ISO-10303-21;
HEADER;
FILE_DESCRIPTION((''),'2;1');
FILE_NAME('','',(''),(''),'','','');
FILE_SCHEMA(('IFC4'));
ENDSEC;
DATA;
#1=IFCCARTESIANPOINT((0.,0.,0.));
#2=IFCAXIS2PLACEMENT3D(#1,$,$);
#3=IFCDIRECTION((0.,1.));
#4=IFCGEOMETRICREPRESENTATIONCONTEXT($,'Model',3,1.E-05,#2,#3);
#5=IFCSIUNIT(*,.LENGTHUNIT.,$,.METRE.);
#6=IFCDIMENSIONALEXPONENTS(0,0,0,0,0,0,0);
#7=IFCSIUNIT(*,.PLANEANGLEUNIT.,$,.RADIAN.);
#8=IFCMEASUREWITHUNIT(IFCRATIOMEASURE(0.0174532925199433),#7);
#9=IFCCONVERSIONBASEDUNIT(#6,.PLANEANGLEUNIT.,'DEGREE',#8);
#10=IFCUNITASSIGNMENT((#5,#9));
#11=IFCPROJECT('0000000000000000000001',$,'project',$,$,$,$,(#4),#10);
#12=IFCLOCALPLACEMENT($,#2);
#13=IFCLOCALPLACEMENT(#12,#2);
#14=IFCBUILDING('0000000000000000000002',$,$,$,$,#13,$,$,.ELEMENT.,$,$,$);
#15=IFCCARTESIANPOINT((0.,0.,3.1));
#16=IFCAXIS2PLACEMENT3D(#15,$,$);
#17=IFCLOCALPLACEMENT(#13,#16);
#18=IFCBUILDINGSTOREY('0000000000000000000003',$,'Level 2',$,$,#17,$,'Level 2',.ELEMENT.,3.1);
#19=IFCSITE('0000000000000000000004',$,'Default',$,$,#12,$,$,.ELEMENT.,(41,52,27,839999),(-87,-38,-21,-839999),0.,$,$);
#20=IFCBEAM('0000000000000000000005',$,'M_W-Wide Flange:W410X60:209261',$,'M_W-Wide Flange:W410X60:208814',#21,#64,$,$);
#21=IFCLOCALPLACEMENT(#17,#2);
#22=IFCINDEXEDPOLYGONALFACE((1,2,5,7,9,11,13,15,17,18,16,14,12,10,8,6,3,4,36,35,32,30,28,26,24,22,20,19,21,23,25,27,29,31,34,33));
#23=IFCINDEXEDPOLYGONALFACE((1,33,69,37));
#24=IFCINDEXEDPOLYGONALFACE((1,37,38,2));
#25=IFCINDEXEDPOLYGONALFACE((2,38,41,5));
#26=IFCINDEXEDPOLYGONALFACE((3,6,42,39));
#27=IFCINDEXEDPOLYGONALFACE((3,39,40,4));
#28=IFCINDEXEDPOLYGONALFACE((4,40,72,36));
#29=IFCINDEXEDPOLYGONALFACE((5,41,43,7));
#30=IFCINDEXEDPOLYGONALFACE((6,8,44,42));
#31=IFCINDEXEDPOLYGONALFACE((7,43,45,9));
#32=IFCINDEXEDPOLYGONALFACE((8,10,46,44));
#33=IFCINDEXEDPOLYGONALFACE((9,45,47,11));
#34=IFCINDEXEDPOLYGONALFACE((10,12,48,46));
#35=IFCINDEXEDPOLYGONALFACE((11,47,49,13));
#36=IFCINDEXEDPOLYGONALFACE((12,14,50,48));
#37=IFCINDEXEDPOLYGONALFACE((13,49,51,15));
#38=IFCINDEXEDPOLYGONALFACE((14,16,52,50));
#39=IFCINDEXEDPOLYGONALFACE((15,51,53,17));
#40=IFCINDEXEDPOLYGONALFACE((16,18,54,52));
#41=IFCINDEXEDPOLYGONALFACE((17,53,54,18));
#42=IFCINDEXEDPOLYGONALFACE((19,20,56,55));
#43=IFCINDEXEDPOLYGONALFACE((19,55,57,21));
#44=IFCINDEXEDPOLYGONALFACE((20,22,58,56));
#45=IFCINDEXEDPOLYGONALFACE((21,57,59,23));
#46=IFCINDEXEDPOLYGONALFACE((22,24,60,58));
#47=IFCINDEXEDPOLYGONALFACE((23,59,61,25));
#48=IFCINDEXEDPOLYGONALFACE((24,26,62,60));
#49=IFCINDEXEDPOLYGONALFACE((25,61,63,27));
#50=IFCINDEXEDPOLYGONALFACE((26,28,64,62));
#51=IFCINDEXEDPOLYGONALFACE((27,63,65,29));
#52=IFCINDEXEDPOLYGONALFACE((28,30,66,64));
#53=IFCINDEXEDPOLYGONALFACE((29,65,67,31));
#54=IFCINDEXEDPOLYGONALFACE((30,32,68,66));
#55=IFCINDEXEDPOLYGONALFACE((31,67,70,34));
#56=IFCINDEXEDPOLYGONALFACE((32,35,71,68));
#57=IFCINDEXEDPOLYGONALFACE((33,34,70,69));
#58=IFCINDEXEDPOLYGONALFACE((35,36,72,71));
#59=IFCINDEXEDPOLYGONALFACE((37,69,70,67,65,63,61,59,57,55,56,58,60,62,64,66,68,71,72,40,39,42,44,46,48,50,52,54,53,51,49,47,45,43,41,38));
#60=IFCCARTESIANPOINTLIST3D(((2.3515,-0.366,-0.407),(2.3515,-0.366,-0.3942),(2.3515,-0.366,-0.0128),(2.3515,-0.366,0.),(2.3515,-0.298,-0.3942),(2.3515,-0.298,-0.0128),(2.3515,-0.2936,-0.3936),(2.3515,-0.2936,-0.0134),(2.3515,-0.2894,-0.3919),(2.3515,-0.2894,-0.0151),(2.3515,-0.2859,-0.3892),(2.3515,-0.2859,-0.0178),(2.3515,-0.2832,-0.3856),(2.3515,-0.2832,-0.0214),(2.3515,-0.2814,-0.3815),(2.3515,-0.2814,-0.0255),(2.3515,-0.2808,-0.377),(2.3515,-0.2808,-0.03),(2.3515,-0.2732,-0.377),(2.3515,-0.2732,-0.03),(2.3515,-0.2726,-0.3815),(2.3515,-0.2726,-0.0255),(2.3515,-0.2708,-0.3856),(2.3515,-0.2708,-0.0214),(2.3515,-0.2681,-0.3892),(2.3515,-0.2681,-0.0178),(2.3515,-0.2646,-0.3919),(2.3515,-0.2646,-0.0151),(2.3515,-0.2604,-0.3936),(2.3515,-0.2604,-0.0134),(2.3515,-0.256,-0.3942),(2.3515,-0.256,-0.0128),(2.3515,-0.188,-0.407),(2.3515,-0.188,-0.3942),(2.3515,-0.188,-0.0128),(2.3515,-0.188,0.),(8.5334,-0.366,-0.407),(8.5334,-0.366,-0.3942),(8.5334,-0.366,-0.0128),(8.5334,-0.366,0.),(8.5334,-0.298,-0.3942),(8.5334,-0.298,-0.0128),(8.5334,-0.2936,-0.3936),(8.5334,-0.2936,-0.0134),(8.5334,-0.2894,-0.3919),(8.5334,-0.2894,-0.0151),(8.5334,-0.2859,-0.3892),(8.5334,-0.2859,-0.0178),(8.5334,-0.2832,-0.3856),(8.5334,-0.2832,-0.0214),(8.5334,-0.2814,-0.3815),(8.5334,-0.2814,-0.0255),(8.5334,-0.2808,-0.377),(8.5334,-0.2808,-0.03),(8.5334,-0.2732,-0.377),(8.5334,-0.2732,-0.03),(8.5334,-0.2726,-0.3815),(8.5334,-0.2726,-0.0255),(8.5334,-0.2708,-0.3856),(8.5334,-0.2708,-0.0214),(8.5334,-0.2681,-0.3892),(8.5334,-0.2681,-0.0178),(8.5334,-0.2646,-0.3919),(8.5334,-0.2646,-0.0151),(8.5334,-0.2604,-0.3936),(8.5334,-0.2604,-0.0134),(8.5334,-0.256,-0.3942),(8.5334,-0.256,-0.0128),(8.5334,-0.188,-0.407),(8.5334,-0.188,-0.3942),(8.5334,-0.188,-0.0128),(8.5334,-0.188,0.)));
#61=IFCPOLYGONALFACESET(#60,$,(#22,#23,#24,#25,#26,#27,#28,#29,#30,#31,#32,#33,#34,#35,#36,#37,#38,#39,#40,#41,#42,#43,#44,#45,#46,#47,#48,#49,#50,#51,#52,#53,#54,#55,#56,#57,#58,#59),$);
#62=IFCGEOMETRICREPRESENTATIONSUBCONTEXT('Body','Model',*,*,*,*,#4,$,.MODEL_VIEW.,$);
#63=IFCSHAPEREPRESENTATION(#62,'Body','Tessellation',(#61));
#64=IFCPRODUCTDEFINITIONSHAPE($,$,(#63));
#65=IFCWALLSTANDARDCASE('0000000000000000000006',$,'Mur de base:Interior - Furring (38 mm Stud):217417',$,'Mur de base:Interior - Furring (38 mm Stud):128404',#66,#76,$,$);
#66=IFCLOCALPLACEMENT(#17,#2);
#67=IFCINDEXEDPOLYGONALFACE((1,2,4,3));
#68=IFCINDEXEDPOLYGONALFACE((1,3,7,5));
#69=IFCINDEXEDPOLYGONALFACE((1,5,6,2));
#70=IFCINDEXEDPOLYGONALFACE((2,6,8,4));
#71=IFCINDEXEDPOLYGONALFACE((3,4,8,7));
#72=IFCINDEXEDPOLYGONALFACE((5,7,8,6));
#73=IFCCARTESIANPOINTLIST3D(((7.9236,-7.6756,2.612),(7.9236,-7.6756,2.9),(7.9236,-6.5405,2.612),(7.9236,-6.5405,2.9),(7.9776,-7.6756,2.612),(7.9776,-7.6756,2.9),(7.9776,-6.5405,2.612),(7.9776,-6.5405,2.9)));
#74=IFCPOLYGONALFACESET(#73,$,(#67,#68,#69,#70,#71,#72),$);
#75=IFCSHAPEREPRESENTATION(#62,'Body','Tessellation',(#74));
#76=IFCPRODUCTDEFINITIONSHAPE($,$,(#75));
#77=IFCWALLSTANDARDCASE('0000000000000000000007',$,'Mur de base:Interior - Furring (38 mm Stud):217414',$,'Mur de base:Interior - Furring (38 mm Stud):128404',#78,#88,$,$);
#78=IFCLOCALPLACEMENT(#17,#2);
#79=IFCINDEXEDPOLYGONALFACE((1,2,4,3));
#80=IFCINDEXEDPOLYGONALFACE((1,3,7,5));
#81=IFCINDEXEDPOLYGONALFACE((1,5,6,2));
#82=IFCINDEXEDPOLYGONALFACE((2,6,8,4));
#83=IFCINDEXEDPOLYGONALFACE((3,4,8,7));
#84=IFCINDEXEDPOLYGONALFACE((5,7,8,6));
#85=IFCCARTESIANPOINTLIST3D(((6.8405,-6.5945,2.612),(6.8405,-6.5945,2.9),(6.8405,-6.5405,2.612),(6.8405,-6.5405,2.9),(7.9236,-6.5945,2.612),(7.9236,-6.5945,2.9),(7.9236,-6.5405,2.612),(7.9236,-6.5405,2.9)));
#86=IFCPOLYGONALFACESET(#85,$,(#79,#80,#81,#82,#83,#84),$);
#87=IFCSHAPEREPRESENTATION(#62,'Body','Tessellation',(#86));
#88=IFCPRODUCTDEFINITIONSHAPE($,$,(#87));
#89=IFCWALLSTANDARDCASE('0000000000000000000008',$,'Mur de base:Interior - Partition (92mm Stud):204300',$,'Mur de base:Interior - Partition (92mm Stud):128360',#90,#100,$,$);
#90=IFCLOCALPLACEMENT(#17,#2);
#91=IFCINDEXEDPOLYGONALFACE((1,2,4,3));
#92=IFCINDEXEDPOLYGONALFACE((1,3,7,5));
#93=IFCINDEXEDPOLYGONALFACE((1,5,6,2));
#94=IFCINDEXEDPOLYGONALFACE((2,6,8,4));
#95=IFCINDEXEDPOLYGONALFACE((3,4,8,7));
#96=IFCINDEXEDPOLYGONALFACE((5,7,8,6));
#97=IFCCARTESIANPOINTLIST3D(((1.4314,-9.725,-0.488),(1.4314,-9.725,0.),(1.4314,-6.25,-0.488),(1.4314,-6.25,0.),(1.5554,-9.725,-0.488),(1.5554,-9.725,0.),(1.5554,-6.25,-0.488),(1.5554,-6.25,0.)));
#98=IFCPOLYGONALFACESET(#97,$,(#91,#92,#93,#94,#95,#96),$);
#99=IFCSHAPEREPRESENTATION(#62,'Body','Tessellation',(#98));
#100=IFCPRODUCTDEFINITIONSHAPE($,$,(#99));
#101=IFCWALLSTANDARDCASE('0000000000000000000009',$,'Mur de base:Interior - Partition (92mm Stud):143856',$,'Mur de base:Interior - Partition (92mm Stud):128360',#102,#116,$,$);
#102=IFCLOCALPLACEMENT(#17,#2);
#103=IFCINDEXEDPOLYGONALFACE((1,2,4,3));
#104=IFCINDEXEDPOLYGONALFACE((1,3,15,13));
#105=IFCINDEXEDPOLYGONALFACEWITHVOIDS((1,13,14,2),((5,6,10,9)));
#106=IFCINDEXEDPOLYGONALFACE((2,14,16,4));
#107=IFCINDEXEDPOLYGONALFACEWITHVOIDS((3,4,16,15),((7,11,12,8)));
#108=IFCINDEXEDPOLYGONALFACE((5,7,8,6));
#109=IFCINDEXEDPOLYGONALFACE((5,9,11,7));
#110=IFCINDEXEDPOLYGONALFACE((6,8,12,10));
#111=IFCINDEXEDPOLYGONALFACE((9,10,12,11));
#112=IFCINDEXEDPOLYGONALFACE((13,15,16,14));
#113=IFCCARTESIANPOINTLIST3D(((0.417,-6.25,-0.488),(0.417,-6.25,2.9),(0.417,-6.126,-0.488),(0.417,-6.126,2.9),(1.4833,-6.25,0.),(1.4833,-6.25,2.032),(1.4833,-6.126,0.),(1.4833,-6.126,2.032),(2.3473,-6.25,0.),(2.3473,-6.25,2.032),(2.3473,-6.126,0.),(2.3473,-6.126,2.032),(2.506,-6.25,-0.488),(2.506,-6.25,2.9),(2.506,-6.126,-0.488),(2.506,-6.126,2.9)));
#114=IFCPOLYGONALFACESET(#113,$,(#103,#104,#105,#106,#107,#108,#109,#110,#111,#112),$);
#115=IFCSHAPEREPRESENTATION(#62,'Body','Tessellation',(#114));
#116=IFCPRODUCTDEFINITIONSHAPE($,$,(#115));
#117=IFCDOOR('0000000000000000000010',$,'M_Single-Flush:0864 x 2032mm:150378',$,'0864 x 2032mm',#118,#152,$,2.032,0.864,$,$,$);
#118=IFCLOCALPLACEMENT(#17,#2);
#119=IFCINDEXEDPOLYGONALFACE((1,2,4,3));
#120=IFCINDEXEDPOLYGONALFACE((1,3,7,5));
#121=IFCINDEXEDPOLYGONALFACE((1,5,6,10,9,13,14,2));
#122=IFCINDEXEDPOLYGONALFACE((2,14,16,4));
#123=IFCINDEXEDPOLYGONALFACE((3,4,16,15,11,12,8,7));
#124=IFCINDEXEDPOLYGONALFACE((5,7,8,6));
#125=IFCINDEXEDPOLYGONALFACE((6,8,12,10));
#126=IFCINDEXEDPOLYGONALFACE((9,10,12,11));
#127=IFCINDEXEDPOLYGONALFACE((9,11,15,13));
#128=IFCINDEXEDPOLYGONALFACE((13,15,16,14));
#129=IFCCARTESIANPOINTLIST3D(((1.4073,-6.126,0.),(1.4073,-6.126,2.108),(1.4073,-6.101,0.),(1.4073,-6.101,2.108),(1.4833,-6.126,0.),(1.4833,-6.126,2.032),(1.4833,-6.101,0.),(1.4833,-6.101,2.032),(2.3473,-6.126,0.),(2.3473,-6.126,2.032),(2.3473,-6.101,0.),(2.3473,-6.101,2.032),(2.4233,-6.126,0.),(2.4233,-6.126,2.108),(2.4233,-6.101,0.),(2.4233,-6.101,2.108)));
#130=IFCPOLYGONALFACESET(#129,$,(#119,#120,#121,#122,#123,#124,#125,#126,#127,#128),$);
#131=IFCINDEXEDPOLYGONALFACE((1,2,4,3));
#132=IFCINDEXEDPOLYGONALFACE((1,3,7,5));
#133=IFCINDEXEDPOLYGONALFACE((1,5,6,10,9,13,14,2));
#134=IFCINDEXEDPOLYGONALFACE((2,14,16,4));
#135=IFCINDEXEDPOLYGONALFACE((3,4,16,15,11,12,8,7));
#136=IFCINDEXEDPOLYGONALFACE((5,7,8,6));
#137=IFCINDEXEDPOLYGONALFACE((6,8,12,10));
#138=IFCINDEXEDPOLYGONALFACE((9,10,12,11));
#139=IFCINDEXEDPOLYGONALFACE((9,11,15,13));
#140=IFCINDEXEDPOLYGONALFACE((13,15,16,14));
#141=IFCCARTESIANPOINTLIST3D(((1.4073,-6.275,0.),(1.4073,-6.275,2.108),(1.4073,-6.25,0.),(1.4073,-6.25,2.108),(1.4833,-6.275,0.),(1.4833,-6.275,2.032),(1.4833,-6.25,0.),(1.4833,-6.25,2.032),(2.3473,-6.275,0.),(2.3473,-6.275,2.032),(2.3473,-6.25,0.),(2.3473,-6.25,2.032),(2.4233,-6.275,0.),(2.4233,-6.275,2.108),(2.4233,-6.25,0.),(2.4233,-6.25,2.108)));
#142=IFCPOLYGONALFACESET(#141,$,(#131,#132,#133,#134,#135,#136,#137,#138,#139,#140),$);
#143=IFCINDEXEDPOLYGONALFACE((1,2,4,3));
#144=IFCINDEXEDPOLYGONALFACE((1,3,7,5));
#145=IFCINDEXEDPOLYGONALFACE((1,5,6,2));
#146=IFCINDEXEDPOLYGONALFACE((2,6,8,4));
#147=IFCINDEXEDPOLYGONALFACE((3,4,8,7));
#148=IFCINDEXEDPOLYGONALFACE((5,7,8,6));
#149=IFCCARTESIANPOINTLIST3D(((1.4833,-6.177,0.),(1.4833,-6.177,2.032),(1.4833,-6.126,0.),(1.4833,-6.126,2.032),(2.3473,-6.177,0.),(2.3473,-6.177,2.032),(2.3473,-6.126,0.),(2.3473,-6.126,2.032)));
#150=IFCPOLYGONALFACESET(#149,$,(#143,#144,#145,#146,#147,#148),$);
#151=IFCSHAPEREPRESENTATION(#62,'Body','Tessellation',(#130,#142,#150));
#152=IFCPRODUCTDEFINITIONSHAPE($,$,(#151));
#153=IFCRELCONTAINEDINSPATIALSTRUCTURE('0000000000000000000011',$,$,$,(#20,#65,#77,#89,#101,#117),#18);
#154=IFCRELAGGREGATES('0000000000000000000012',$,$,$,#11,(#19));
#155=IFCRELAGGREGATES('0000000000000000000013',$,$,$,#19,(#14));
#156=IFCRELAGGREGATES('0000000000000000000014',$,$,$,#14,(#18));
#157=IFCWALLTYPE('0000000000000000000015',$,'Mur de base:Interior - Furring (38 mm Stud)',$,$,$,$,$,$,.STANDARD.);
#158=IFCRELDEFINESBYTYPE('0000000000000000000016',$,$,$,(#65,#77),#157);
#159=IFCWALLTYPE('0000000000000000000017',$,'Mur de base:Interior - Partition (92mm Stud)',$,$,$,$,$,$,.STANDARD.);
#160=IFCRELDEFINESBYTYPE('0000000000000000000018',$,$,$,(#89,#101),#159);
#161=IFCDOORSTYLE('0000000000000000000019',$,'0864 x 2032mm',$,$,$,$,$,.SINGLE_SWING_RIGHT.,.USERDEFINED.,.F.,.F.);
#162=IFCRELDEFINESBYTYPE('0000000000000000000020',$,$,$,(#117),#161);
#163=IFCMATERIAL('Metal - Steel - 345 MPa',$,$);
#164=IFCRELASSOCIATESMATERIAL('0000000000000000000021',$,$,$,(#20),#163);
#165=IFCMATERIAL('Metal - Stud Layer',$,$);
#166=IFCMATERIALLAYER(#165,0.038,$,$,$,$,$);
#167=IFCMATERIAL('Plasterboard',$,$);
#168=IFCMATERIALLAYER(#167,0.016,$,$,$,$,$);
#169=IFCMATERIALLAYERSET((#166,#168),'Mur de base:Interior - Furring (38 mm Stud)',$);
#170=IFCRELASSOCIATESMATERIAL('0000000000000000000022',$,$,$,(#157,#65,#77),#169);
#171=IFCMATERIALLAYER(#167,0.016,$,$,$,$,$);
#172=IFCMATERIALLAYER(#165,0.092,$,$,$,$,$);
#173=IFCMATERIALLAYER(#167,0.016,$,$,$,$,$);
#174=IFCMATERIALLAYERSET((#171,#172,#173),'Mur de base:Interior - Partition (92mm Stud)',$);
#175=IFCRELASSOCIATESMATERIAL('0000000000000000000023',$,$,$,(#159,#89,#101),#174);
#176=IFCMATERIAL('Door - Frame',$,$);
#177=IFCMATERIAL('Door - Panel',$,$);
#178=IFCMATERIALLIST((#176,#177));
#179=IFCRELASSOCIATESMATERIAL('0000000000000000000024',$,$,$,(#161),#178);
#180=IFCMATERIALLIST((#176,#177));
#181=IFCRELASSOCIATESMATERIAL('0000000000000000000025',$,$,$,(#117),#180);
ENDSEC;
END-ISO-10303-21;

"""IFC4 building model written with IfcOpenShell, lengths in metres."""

from ifc_helpers import new_model, entity, si_unit, converted_unit, direction, frame, frame_2d, origin, origin_2d_with_axis, place, context, subcontext, project, spatial, polyline, rectangle, i_section, outline, extrude, source, transform, mapped, material, material_list, layer, layer_set, layer_usage, type_object, type_shapes, element, fill, save


model = new_model("IFC4")

# Units and contexts
model_context = context("Model", 3, precision=1e-05, world=origin(), true_north=direction((0.0, 1.0)))
body_context = subcontext(model_context, "Body", "Model", "MODEL_VIEW")
ifc_project = project(units=[si_unit("LENGTHUNIT", "METRE"), converted_unit("PLANEANGLEUNIT", "DEGREE", entity("IfcRatioMeasure", 0.0174532925199433), si_unit("PLANEANGLEUNIT", "RADIAN"), dimensions=[0, 0, 0, 0, 0, 0, 0])], contexts=[model_context])

# Site, building, storey
site_placement = place(None, origin())
site = spatial("IfcSite", under=ifc_project, at=site_placement, Name="Default", CompositionType="ELEMENT", RefLatitude=(41, 52, 27, 839999), RefLongitude=(-87, -38, -21, -839999), RefElevation=0.0)
building_placement = place(site_placement, origin())
building = spatial("IfcBuilding", under=site, at=building_placement, CompositionType="ELEMENT")
storey_placement = place(building_placement, frame((0.0, 0.0, 3.1)))
storey = spatial("IfcBuildingStorey", under=building, at=storey_placement, Name="Level 2", LongName="Level 2", CompositionType="ELEMENT", Elevation=3.1)

# Beam
ifc_material_1 = material(Name="Metal - Steel - 345 MPa")
beam_placement = place(storey_placement, frame((8.5334, -0.277, 0.0), z_axis=(0.0, 0.0, 1.0), x_axis=(-1.0, 0.0, 0.0)))
element("IfcBeam", 1, at=beam_placement, inside=storey, material=ifc_material_1, Name="M_W-Wide Flange:W410X60:209261", ObjectType="M_W-Wide Flange:W410X60:208814", context=body_context, shape_type="SweptSolid", body=[
    extrude(i_section(OverallWidth=0.178, OverallDepth=0.407, WebThickness=0.0077, FlangeThickness=0.0128, FilletRadius=0.0172, at=frame_2d((0.0, 0.0), x_axis=(0.0, 1.0))), frame((0.0, 0.0, -0.2035), z_axis=(1.0, 0.0, 0.0), x_axis=(0.0, 0.0, -1.0)), (0.0, 0.0, 1.0), 6.1819),
])

# Walls
ifc_material_2 = material(Name="Metal - Stud Layer")
ifc_layer_1 = layer(ifc_material_2, 0.038)
ifc_material_3 = material(Name="Plasterboard")
ifc_layer_2 = layer(ifc_material_3, 0.016)
ifc_layer_set_1 = layer_set([ifc_layer_1, ifc_layer_2], Name="Mur de base:Interior - Furring (38 mm Stud)")
ifc_layer_usage_1 = layer_usage(ifc_layer_set_1, "AXIS2", "NEGATIVE", 0.027)
wall_type_1 = type_object("IfcWallType", Name="Mur de base:Interior - Furring (38 mm Stud)", PredefinedType="STANDARD", material=ifc_layer_set_1)
wall_1_placement = place(storey_placement, frame((7.9506, -6.5405, 2.612), z_axis=(0.0, 0.0, 1.0), x_axis=(0.0, -1.0, 0.0)))
element("IfcWallStandardCase", 2, at=wall_1_placement, inside=storey, type_object=wall_type_1, material=ifc_layer_usage_1, Name="Mur de base:Interior - Furring (38 mm Stud):217417", ObjectType="Mur de base:Interior - Furring (38 mm Stud):128404", context=body_context, shape_type="SweptSolid", body=[
    extrude(rectangle(XDim=1.1351, YDim=0.054, at=frame_2d((0.5675, 0.0), x_axis=(-1.0, 0.0))), origin(), (0.0, 0.0, 1.0), 0.288),
])
ifc_layer_usage_2 = layer_usage(ifc_layer_set_1, "AXIS2", "NEGATIVE", 0.027)
wall_2_placement = place(storey_placement, frame((6.8405, -6.5675, 2.612)))
element("IfcWallStandardCase", 3, at=wall_2_placement, inside=storey, type_object=wall_type_1, material=ifc_layer_usage_2, Name="Mur de base:Interior - Furring (38 mm Stud):217414", ObjectType="Mur de base:Interior - Furring (38 mm Stud):128404", context=body_context, shape_type="SweptSolid", body=[
    extrude(rectangle(XDim=1.0831, YDim=0.054, at=frame_2d((0.5415, 0.0), x_axis=(-1.0, 0.0))), origin(), (0.0, 0.0, 1.0), 0.288),
])
ifc_layer_3 = layer(ifc_material_3, 0.016)
ifc_layer_4 = layer(ifc_material_2, 0.092)
ifc_layer_5 = layer(ifc_material_3, 0.016)
ifc_layer_set_2 = layer_set([ifc_layer_3, ifc_layer_4, ifc_layer_5], Name="Mur de base:Interior - Partition (92mm Stud)")
ifc_layer_usage_3 = layer_usage(ifc_layer_set_2, "AXIS2", "NEGATIVE", 0.062)
wall_type_2 = type_object("IfcWallType", Name="Mur de base:Interior - Partition (92mm Stud)", PredefinedType="STANDARD", material=ifc_layer_set_2)
wall_3_placement = place(storey_placement, frame((1.4934, -6.25, -0.488), z_axis=(0.0, 0.0, 1.0), x_axis=(0.0, -1.0, 0.0)))
element("IfcWallStandardCase", 4, at=wall_3_placement, inside=storey, type_object=wall_type_2, material=ifc_layer_usage_3, Name="Mur de base:Interior - Partition (92mm Stud):204300", ObjectType="Mur de base:Interior - Partition (92mm Stud):128360", context=body_context, shape_type="SweptSolid", body=[
    extrude(rectangle(XDim=3.475, YDim=0.124, at=frame_2d((1.7375, 0.0), x_axis=(-1.0, 0.0))), origin(), (0.0, 0.0, 1.0), 0.488),
])

# Wall, opening, door
ifc_layer_usage_4 = layer_usage(ifc_layer_set_2, "AXIS2", "NEGATIVE", 0.062)
wall_4_placement = place(storey_placement, frame((0.417, -6.188, -0.488)))
wall_4 = element("IfcWallStandardCase", 5, at=wall_4_placement, inside=storey, type_object=wall_type_2, material=ifc_layer_usage_4, Name="Mur de base:Interior - Partition (92mm Stud):143856", ObjectType="Mur de base:Interior - Partition (92mm Stud):128360", context=body_context, shape_type="SweptSolid", body=[
    extrude(rectangle(XDim=2.089, YDim=0.124, at=frame_2d((1.0445, 0.0), x_axis=(-1.0, 0.0))), origin(), (0.0, 0.0, 1.0), 3.388),
])
opening_1_placement = place(wall_4_placement, frame((1.0663, -0.062, 0.488)))
opening_1 = element("IfcOpeningElement", 6, at=opening_1_placement, cuts=wall_4, ObjectType="Opening", context=body_context, shape_type="SweptSolid", body=[
    extrude(rectangle(XDim=0.864, YDim=2.032, at=frame_2d((1.016, 0.432), x_axis=(0.0, 1.0))), frame((0.0, 0.0, 0.0), z_axis=(0.0, 1.0, 0.0), x_axis=(0.0, 0.0, 1.0)), (0.0, 0.0, 1.0), 0.124),
])
ifc_material_4 = material(Name="Door - Frame")
ifc_material_5 = material(Name="Door - Panel")
ifc_material_list_1 = material_list([ifc_material_4, ifc_material_5])
ifc_material_list_2 = material_list([ifc_material_4, ifc_material_5])
door_style_1 = type_object("IfcDoorStyle", Name="0864 x 2032mm", ConstructionType="USERDEFINED", OperationType="SINGLE_SWING_RIGHT", ParameterTakesPrecedence=False, Sizeable=False, material=ifc_material_list_2)
shared_shape_1 = source(origin(), body_context, "Body", "SweptSolid", [
    extrude(outline(polyline([(-0.508, -1.073), (0.508, -1.073), (0.508, 1.035), (0.432, 1.035), (0.432, -0.997), (-0.432, -0.997), (-0.432, 1.035), (-0.508, 1.035), (-0.508, -1.073)])), frame((0.432, 0.124, 1.035), z_axis=(0.0, 1.0, 0.0), x_axis=(1.0, 0.0, 0.0)), (0.0, 0.0, 1.0), 0.025),
    extrude(outline(polyline([(-1.073, -0.508), (1.035, -0.508), (1.035, -0.432), (-0.997, -0.432), (-0.997, 0.432), (1.035, 0.432), (1.035, 0.508), (-1.073, 0.508), (-1.073, -0.508)])), frame((0.432, -0.025, 1.035), z_axis=(0.0, 1.0, 0.0), x_axis=(0.0, 0.0, -1.0)), (0.0, 0.0, 1.0), 0.025),
    extrude(rectangle(XDim=0.051, YDim=0.864, at=origin_2d_with_axis()), frame((0.432, 0.0985, 0.0), z_axis=(0.0, 0.0, 1.0), x_axis=(0.0, 1.0, 0.0)), (0.0, 0.0, 1.0), 2.032),
])
type_shapes(door_style_1, [shared_shape_1])
door_1_placement = place(opening_1_placement, origin())
door_1 = element("IfcDoor", 7, at=door_1_placement, inside=storey, type_object=door_style_1, material=ifc_material_list_1, Name="M_Single-Flush:0864 x 2032mm:150378", ObjectType="0864 x 2032mm", OverallHeight=2.032, OverallWidth=0.864, context=body_context, shape_type="MappedRepresentation", body=[
    mapped(shared_shape_1, transform((0.0, 0.0, 0.0), scale=1.0)),
])
fill(opening_1, door_1)

save(model, "model.ifc")
